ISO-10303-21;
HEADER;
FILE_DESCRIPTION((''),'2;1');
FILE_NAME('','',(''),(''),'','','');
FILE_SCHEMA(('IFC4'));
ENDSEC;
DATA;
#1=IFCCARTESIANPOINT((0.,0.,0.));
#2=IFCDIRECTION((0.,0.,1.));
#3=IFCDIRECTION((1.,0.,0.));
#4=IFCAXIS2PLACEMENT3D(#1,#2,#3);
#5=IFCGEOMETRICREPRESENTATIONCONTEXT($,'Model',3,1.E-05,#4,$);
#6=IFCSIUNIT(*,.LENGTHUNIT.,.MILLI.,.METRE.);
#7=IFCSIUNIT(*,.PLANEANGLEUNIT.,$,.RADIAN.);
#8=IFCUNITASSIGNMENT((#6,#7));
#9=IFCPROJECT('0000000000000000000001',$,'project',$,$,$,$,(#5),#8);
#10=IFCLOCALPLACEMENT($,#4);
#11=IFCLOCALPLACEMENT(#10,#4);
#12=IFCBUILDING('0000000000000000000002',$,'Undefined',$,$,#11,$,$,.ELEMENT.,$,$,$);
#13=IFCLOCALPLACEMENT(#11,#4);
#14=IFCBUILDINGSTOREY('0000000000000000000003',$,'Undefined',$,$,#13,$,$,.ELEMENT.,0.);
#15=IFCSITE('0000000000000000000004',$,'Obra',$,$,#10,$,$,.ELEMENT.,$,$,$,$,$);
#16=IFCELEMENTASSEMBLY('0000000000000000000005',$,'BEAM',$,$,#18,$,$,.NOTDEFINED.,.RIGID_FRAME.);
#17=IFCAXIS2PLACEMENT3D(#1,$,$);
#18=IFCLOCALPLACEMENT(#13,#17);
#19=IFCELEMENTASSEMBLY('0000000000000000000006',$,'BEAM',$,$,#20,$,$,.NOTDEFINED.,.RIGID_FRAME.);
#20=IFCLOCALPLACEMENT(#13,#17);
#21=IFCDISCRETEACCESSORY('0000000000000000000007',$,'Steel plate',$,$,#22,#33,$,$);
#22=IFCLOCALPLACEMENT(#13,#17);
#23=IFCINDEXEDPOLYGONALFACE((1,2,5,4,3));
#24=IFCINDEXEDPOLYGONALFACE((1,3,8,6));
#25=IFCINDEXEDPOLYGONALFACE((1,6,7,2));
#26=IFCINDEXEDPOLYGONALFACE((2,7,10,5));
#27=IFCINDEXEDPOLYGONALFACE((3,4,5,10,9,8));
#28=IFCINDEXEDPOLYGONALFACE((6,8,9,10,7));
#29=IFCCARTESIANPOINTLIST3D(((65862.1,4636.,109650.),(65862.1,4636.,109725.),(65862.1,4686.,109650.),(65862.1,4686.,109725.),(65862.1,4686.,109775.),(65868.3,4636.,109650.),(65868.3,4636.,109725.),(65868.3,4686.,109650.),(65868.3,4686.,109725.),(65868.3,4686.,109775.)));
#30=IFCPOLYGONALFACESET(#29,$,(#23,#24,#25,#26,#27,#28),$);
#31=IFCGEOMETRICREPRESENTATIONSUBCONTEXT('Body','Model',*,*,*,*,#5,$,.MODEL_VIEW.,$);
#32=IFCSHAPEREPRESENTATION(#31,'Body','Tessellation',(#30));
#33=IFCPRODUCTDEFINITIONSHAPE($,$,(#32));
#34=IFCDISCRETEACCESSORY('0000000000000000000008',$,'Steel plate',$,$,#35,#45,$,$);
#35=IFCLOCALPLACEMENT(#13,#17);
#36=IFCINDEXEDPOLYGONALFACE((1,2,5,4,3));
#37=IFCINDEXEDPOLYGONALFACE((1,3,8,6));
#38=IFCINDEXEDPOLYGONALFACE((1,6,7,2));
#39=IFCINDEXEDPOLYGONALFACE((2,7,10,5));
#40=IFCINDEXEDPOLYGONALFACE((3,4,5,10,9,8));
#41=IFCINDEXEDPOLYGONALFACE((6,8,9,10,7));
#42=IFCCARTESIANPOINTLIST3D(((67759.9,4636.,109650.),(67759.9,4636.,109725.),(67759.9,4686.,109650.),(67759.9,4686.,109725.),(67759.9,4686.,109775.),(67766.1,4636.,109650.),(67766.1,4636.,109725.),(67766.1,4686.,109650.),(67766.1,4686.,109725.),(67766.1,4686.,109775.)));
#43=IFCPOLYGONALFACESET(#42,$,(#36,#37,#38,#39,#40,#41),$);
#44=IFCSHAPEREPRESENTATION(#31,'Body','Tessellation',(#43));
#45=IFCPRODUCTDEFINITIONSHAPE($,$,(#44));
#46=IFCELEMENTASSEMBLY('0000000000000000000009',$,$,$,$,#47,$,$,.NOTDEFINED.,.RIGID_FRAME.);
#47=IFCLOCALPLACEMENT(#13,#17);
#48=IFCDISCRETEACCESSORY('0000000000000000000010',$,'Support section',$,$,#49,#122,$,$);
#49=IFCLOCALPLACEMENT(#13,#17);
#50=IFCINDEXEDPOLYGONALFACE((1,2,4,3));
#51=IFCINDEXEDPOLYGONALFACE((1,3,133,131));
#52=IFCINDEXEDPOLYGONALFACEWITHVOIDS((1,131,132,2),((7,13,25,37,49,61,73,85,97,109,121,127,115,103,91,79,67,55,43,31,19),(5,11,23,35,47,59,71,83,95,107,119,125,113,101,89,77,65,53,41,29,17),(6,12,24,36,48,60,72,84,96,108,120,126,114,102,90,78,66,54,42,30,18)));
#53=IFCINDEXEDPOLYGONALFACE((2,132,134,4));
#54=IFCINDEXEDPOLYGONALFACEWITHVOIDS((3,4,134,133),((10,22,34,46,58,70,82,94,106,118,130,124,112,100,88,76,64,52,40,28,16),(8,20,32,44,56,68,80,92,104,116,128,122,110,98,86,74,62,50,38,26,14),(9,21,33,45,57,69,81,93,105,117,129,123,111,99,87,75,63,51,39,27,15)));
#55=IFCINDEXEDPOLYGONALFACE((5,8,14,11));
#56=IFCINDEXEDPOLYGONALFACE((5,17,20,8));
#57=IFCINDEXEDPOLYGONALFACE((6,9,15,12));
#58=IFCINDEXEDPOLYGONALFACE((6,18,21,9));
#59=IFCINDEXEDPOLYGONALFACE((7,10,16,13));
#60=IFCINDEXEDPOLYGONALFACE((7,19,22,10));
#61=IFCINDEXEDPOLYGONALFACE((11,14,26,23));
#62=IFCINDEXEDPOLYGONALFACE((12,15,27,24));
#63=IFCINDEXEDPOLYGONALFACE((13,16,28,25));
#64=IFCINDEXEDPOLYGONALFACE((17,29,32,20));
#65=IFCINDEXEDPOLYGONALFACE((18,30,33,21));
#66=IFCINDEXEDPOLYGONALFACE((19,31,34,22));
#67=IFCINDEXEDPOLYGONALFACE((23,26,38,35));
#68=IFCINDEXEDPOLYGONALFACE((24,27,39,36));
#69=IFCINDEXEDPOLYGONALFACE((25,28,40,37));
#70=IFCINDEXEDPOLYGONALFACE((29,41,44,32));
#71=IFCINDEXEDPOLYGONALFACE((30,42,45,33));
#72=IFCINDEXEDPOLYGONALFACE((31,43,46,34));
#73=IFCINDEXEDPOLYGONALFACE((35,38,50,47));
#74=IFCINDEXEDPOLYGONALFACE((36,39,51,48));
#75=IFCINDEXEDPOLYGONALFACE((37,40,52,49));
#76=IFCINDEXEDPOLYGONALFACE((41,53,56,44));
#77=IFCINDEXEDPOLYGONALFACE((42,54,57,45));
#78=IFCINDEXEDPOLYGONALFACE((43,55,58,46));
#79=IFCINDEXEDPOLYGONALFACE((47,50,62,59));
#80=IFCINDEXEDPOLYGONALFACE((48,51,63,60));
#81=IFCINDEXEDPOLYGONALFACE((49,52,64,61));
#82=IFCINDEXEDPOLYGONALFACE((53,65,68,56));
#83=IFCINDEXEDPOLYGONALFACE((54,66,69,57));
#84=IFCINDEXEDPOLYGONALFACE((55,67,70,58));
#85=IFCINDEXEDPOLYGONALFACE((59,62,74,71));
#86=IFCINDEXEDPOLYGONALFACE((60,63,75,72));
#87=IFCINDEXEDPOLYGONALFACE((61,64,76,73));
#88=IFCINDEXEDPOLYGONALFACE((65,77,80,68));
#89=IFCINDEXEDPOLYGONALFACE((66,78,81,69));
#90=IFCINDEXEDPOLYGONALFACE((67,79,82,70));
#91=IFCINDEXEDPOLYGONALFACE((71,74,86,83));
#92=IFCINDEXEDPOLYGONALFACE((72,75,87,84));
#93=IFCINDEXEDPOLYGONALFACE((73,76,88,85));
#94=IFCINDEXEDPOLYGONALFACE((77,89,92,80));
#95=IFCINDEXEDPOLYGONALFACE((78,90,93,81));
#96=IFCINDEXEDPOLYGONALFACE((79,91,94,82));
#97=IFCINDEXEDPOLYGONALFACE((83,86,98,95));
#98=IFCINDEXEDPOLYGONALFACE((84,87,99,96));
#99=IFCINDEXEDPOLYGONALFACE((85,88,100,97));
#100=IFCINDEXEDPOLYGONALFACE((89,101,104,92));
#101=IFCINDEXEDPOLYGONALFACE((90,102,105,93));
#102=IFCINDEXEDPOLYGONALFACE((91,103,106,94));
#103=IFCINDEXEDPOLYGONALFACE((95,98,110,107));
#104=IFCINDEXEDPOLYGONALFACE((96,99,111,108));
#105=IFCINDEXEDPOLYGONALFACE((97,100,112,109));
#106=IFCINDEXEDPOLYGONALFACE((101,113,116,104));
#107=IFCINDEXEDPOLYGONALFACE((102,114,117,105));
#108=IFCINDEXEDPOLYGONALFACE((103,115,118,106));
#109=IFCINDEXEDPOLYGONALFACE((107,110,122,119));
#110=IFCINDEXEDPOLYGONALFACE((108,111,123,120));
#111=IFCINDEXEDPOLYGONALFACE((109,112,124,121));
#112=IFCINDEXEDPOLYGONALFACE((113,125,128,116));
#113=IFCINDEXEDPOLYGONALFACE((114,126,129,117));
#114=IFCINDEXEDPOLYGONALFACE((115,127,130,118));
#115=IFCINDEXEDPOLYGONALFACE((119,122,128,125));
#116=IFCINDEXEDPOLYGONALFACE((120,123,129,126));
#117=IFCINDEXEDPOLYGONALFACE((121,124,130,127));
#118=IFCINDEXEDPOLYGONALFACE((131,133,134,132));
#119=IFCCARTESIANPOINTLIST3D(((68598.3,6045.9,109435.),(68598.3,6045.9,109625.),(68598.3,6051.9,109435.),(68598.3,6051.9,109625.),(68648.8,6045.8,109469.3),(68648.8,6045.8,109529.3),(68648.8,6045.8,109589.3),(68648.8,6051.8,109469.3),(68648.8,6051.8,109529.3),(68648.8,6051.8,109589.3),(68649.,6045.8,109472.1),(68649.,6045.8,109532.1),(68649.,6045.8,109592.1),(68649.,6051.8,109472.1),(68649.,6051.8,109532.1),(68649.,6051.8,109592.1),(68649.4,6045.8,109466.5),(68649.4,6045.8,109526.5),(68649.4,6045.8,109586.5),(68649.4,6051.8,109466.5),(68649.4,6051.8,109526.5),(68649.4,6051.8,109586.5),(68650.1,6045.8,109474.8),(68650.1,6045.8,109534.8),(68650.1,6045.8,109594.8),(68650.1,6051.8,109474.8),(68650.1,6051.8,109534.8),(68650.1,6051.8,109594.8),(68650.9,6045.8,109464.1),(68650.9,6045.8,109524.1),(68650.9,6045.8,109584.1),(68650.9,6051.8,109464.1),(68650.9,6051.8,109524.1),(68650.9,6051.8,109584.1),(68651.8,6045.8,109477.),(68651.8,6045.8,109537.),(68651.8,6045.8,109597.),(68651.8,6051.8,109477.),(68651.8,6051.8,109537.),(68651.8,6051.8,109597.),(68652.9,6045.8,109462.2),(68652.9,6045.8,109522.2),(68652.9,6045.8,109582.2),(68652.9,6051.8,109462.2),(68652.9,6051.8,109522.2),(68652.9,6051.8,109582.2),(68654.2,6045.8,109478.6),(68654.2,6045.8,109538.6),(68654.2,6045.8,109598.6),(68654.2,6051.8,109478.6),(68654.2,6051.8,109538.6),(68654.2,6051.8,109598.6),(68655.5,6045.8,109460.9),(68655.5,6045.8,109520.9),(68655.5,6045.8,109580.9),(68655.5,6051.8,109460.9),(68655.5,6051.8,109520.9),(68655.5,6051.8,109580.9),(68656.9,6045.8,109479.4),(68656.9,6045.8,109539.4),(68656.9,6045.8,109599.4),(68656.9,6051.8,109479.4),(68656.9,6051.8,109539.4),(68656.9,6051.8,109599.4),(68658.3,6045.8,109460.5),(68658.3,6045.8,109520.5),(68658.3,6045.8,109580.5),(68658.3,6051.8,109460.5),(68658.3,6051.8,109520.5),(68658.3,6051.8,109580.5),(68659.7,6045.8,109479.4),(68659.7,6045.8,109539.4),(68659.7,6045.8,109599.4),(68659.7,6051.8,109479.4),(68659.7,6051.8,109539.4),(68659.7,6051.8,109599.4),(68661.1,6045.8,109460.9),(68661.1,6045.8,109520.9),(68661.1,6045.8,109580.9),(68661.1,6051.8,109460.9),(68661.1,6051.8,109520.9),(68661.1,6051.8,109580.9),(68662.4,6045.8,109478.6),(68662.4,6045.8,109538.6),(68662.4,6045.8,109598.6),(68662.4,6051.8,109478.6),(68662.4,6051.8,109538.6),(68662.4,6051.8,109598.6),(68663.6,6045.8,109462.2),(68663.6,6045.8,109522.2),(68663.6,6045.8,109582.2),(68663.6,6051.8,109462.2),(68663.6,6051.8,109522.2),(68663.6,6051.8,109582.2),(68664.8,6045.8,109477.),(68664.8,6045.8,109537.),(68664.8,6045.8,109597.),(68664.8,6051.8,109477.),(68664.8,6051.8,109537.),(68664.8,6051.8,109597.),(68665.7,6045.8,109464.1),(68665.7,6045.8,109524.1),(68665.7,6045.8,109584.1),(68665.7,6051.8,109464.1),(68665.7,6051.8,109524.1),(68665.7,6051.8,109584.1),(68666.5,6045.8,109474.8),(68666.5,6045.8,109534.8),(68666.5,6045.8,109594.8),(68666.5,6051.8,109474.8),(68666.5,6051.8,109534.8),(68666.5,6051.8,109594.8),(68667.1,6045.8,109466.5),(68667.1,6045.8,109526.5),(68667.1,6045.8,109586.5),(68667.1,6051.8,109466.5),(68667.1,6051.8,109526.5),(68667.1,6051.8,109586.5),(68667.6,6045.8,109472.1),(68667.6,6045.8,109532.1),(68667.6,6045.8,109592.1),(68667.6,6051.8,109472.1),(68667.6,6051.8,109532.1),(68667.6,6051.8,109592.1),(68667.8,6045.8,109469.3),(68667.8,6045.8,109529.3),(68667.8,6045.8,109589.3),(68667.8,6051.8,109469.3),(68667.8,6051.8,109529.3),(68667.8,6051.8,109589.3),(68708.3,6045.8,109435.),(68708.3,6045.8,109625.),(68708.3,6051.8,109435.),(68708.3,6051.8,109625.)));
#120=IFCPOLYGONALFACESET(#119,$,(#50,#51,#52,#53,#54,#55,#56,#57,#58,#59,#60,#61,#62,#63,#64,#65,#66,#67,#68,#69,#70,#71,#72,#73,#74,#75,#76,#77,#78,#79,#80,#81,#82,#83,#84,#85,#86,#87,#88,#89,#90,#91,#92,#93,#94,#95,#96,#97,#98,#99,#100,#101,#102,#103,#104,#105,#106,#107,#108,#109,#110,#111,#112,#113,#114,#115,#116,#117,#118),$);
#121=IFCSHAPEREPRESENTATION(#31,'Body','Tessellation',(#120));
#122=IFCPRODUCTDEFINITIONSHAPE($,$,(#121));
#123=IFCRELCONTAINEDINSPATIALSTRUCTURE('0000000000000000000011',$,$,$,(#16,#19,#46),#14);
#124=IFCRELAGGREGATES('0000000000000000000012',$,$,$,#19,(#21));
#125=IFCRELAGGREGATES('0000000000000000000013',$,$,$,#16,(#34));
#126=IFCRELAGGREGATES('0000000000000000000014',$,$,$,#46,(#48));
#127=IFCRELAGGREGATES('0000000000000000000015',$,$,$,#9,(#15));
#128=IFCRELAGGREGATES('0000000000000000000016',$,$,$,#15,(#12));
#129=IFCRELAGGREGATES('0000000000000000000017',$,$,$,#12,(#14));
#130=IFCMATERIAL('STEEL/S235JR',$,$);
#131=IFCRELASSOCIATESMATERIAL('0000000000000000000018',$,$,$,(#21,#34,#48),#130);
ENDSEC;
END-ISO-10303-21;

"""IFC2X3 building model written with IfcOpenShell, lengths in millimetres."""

from ifc_helpers import new_model, si_unit, frame, origin_with_axes, origin_2d_with_axis, place, context, subcontext, project, spatial, polyline, rectangle, circle, outline, extrude, source, transform, mapped, material, element, aggregate, save


model = new_model("IFC2X3")

# Units and contexts
model_context = context("Model", 3, precision=1e-05, world=origin_with_axes())
body_context = subcontext(model_context, "Body", "Model", "MODEL_VIEW")
ifc_project = project(units=[si_unit("LENGTHUNIT", "METRE", prefix="MILLI"), si_unit("PLANEANGLEUNIT", "RADIAN")], contexts=[model_context])

# Site, building, storey
site_placement = place(None, origin_with_axes())
site = spatial("IfcSite", under=ifc_project, at=site_placement, Name="Obra", CompositionType="ELEMENT")
building_placement = place(site_placement, origin_with_axes())
building = spatial("IfcBuilding", under=site, at=building_placement, Name="Undefined", CompositionType="ELEMENT")
storey_placement = place(building_placement, origin_with_axes())
storey = spatial("IfcBuildingStorey", under=building, at=storey_placement, Name="Undefined", CompositionType="ELEMENT", Elevation=0.0)

# Element assembly
ifc_material_1 = material(Name="STEEL/S235JR")
assembly_1_placement = place(storey_placement, origin_with_axes())
assembly_1 = element("IfcElementAssembly", 1, at=assembly_1_placement, inside=storey, Name="BEAM", AssemblyPlace="NOTDEFINED", PredefinedType="RIGID_FRAME")

# Element assembly
assembly_2_placement = place(storey_placement, origin_with_axes())
assembly_2 = element("IfcElementAssembly", 2, at=assembly_2_placement, inside=storey, Name="BEAM", AssemblyPlace="NOTDEFINED", PredefinedType="RIGID_FRAME")

# Discrete accessories
discrete_accessory_1_placement = place(assembly_2_placement, frame((65865.2, 4686.0, 109725.0), z_axis=(-1.0, 0.0, 0.0), x_axis=(0.0, 0.0, -1.0)))
discrete_accessory_1 = element("IfcDiscreteAccessory", 3, at=discrete_accessory_1_placement, material=ifc_material_1, Name="Steel plate", context=body_context, shape_type="SweptSolid", body=[
    extrude(outline(polyline([(0.0, 0.0), (75.0, 0.0), (75.0, 50.0), (0.0, 50.0), (-75.0, -25.0), (-75.0, 0.0), (0.0, 0.0)])), frame((0.0, 0.0, -3.1), z_axis=(0.0, 0.0, 1.0), x_axis=(1.0, 0.0, 0.0)), (0.0, 0.0, 1.0), 6.2),
])
aggregate(assembly_2, [discrete_accessory_1])
discrete_accessory_2_placement = place(assembly_1_placement, frame((67763.0, 4686.0, 109725.0), z_axis=(-1.0, 0.0, 0.0), x_axis=(0.0, 0.0, -1.0)))
discrete_accessory_2 = element("IfcDiscreteAccessory", 4, at=discrete_accessory_2_placement, material=ifc_material_1, Name="Steel plate", context=body_context, shape_type="SweptSolid", body=[
    extrude(outline(polyline([(0.0, 0.0), (75.0, 0.0), (75.0, 50.0), (0.0, 50.0), (-75.0, -25.0), (-75.0, 0.0), (0.0, 0.0)])), frame((0.0, 0.0, -3.1), z_axis=(0.0, 0.0, 1.0), x_axis=(1.0, 0.0, 0.0)), (0.0, 0.0, 1.0), 6.2),
])
aggregate(assembly_1, [discrete_accessory_2])

# Element assembly, discrete accessory, opening
assembly_3_placement = place(storey_placement, origin_with_axes())
assembly_3 = element("IfcElementAssembly", 5, at=assembly_3_placement, inside=storey, AssemblyPlace="NOTDEFINED", PredefinedType="RIGID_FRAME")
discrete_accessory_3_placement = place(assembly_3_placement, frame((68653.3, 6048.8, 109435.0), z_axis=(0.0, 0.0, 1.0), x_axis=(-1.0, 0.000126, 0.0)))
discrete_accessory_3 = element("IfcDiscreteAccessory", 6, at=discrete_accessory_3_placement, material=ifc_material_1, Name="Support section", context=body_context, shape_type="SweptSolid", body=[
    extrude(rectangle(XDim=6.0, YDim=110.0, at=origin_2d_with_axis()), frame((0.0, 0.0, 190.0), z_axis=(0.0, 0.0, -1.0), x_axis=(0.0, 1.0, 0.0)), (0.0, 0.0, 1.0), 190.0),
])
shared_shape_1 = source(origin_with_axes(), body_context, "Body", "SweptSolid", [
    extrude(circle(Radius=9.5, at=origin_2d_with_axis()), frame((0.0, -9.2, 0.0), z_axis=(0.0, 1.0, 0.0), x_axis=(1.0, 0.0, 0.0)), (0.0, 0.0, 1.0), 6.2),
])
opening_1_placement = place(assembly_3_placement, frame((68608.3, 6055.0, 109650.0), z_axis=(1.0, -0.000126, 0.0), x_axis=(0.0, 0.0, -1.0)))
element("IfcOpeningElement", 7, at=opening_1_placement, cuts=discrete_accessory_3, ObjectType="Opening", context=body_context, shape_type="MappedRepresentation", body=[
    mapped(shared_shape_1, transform((60.0, 0.0, 50.0))),
    mapped(shared_shape_1, transform((120.0, 0.0, 50.0))),
    mapped(shared_shape_1, transform((180.0, 0.0, 50.0))),
])
aggregate(assembly_3, [discrete_accessory_3])

save(model, "model.ifc")
